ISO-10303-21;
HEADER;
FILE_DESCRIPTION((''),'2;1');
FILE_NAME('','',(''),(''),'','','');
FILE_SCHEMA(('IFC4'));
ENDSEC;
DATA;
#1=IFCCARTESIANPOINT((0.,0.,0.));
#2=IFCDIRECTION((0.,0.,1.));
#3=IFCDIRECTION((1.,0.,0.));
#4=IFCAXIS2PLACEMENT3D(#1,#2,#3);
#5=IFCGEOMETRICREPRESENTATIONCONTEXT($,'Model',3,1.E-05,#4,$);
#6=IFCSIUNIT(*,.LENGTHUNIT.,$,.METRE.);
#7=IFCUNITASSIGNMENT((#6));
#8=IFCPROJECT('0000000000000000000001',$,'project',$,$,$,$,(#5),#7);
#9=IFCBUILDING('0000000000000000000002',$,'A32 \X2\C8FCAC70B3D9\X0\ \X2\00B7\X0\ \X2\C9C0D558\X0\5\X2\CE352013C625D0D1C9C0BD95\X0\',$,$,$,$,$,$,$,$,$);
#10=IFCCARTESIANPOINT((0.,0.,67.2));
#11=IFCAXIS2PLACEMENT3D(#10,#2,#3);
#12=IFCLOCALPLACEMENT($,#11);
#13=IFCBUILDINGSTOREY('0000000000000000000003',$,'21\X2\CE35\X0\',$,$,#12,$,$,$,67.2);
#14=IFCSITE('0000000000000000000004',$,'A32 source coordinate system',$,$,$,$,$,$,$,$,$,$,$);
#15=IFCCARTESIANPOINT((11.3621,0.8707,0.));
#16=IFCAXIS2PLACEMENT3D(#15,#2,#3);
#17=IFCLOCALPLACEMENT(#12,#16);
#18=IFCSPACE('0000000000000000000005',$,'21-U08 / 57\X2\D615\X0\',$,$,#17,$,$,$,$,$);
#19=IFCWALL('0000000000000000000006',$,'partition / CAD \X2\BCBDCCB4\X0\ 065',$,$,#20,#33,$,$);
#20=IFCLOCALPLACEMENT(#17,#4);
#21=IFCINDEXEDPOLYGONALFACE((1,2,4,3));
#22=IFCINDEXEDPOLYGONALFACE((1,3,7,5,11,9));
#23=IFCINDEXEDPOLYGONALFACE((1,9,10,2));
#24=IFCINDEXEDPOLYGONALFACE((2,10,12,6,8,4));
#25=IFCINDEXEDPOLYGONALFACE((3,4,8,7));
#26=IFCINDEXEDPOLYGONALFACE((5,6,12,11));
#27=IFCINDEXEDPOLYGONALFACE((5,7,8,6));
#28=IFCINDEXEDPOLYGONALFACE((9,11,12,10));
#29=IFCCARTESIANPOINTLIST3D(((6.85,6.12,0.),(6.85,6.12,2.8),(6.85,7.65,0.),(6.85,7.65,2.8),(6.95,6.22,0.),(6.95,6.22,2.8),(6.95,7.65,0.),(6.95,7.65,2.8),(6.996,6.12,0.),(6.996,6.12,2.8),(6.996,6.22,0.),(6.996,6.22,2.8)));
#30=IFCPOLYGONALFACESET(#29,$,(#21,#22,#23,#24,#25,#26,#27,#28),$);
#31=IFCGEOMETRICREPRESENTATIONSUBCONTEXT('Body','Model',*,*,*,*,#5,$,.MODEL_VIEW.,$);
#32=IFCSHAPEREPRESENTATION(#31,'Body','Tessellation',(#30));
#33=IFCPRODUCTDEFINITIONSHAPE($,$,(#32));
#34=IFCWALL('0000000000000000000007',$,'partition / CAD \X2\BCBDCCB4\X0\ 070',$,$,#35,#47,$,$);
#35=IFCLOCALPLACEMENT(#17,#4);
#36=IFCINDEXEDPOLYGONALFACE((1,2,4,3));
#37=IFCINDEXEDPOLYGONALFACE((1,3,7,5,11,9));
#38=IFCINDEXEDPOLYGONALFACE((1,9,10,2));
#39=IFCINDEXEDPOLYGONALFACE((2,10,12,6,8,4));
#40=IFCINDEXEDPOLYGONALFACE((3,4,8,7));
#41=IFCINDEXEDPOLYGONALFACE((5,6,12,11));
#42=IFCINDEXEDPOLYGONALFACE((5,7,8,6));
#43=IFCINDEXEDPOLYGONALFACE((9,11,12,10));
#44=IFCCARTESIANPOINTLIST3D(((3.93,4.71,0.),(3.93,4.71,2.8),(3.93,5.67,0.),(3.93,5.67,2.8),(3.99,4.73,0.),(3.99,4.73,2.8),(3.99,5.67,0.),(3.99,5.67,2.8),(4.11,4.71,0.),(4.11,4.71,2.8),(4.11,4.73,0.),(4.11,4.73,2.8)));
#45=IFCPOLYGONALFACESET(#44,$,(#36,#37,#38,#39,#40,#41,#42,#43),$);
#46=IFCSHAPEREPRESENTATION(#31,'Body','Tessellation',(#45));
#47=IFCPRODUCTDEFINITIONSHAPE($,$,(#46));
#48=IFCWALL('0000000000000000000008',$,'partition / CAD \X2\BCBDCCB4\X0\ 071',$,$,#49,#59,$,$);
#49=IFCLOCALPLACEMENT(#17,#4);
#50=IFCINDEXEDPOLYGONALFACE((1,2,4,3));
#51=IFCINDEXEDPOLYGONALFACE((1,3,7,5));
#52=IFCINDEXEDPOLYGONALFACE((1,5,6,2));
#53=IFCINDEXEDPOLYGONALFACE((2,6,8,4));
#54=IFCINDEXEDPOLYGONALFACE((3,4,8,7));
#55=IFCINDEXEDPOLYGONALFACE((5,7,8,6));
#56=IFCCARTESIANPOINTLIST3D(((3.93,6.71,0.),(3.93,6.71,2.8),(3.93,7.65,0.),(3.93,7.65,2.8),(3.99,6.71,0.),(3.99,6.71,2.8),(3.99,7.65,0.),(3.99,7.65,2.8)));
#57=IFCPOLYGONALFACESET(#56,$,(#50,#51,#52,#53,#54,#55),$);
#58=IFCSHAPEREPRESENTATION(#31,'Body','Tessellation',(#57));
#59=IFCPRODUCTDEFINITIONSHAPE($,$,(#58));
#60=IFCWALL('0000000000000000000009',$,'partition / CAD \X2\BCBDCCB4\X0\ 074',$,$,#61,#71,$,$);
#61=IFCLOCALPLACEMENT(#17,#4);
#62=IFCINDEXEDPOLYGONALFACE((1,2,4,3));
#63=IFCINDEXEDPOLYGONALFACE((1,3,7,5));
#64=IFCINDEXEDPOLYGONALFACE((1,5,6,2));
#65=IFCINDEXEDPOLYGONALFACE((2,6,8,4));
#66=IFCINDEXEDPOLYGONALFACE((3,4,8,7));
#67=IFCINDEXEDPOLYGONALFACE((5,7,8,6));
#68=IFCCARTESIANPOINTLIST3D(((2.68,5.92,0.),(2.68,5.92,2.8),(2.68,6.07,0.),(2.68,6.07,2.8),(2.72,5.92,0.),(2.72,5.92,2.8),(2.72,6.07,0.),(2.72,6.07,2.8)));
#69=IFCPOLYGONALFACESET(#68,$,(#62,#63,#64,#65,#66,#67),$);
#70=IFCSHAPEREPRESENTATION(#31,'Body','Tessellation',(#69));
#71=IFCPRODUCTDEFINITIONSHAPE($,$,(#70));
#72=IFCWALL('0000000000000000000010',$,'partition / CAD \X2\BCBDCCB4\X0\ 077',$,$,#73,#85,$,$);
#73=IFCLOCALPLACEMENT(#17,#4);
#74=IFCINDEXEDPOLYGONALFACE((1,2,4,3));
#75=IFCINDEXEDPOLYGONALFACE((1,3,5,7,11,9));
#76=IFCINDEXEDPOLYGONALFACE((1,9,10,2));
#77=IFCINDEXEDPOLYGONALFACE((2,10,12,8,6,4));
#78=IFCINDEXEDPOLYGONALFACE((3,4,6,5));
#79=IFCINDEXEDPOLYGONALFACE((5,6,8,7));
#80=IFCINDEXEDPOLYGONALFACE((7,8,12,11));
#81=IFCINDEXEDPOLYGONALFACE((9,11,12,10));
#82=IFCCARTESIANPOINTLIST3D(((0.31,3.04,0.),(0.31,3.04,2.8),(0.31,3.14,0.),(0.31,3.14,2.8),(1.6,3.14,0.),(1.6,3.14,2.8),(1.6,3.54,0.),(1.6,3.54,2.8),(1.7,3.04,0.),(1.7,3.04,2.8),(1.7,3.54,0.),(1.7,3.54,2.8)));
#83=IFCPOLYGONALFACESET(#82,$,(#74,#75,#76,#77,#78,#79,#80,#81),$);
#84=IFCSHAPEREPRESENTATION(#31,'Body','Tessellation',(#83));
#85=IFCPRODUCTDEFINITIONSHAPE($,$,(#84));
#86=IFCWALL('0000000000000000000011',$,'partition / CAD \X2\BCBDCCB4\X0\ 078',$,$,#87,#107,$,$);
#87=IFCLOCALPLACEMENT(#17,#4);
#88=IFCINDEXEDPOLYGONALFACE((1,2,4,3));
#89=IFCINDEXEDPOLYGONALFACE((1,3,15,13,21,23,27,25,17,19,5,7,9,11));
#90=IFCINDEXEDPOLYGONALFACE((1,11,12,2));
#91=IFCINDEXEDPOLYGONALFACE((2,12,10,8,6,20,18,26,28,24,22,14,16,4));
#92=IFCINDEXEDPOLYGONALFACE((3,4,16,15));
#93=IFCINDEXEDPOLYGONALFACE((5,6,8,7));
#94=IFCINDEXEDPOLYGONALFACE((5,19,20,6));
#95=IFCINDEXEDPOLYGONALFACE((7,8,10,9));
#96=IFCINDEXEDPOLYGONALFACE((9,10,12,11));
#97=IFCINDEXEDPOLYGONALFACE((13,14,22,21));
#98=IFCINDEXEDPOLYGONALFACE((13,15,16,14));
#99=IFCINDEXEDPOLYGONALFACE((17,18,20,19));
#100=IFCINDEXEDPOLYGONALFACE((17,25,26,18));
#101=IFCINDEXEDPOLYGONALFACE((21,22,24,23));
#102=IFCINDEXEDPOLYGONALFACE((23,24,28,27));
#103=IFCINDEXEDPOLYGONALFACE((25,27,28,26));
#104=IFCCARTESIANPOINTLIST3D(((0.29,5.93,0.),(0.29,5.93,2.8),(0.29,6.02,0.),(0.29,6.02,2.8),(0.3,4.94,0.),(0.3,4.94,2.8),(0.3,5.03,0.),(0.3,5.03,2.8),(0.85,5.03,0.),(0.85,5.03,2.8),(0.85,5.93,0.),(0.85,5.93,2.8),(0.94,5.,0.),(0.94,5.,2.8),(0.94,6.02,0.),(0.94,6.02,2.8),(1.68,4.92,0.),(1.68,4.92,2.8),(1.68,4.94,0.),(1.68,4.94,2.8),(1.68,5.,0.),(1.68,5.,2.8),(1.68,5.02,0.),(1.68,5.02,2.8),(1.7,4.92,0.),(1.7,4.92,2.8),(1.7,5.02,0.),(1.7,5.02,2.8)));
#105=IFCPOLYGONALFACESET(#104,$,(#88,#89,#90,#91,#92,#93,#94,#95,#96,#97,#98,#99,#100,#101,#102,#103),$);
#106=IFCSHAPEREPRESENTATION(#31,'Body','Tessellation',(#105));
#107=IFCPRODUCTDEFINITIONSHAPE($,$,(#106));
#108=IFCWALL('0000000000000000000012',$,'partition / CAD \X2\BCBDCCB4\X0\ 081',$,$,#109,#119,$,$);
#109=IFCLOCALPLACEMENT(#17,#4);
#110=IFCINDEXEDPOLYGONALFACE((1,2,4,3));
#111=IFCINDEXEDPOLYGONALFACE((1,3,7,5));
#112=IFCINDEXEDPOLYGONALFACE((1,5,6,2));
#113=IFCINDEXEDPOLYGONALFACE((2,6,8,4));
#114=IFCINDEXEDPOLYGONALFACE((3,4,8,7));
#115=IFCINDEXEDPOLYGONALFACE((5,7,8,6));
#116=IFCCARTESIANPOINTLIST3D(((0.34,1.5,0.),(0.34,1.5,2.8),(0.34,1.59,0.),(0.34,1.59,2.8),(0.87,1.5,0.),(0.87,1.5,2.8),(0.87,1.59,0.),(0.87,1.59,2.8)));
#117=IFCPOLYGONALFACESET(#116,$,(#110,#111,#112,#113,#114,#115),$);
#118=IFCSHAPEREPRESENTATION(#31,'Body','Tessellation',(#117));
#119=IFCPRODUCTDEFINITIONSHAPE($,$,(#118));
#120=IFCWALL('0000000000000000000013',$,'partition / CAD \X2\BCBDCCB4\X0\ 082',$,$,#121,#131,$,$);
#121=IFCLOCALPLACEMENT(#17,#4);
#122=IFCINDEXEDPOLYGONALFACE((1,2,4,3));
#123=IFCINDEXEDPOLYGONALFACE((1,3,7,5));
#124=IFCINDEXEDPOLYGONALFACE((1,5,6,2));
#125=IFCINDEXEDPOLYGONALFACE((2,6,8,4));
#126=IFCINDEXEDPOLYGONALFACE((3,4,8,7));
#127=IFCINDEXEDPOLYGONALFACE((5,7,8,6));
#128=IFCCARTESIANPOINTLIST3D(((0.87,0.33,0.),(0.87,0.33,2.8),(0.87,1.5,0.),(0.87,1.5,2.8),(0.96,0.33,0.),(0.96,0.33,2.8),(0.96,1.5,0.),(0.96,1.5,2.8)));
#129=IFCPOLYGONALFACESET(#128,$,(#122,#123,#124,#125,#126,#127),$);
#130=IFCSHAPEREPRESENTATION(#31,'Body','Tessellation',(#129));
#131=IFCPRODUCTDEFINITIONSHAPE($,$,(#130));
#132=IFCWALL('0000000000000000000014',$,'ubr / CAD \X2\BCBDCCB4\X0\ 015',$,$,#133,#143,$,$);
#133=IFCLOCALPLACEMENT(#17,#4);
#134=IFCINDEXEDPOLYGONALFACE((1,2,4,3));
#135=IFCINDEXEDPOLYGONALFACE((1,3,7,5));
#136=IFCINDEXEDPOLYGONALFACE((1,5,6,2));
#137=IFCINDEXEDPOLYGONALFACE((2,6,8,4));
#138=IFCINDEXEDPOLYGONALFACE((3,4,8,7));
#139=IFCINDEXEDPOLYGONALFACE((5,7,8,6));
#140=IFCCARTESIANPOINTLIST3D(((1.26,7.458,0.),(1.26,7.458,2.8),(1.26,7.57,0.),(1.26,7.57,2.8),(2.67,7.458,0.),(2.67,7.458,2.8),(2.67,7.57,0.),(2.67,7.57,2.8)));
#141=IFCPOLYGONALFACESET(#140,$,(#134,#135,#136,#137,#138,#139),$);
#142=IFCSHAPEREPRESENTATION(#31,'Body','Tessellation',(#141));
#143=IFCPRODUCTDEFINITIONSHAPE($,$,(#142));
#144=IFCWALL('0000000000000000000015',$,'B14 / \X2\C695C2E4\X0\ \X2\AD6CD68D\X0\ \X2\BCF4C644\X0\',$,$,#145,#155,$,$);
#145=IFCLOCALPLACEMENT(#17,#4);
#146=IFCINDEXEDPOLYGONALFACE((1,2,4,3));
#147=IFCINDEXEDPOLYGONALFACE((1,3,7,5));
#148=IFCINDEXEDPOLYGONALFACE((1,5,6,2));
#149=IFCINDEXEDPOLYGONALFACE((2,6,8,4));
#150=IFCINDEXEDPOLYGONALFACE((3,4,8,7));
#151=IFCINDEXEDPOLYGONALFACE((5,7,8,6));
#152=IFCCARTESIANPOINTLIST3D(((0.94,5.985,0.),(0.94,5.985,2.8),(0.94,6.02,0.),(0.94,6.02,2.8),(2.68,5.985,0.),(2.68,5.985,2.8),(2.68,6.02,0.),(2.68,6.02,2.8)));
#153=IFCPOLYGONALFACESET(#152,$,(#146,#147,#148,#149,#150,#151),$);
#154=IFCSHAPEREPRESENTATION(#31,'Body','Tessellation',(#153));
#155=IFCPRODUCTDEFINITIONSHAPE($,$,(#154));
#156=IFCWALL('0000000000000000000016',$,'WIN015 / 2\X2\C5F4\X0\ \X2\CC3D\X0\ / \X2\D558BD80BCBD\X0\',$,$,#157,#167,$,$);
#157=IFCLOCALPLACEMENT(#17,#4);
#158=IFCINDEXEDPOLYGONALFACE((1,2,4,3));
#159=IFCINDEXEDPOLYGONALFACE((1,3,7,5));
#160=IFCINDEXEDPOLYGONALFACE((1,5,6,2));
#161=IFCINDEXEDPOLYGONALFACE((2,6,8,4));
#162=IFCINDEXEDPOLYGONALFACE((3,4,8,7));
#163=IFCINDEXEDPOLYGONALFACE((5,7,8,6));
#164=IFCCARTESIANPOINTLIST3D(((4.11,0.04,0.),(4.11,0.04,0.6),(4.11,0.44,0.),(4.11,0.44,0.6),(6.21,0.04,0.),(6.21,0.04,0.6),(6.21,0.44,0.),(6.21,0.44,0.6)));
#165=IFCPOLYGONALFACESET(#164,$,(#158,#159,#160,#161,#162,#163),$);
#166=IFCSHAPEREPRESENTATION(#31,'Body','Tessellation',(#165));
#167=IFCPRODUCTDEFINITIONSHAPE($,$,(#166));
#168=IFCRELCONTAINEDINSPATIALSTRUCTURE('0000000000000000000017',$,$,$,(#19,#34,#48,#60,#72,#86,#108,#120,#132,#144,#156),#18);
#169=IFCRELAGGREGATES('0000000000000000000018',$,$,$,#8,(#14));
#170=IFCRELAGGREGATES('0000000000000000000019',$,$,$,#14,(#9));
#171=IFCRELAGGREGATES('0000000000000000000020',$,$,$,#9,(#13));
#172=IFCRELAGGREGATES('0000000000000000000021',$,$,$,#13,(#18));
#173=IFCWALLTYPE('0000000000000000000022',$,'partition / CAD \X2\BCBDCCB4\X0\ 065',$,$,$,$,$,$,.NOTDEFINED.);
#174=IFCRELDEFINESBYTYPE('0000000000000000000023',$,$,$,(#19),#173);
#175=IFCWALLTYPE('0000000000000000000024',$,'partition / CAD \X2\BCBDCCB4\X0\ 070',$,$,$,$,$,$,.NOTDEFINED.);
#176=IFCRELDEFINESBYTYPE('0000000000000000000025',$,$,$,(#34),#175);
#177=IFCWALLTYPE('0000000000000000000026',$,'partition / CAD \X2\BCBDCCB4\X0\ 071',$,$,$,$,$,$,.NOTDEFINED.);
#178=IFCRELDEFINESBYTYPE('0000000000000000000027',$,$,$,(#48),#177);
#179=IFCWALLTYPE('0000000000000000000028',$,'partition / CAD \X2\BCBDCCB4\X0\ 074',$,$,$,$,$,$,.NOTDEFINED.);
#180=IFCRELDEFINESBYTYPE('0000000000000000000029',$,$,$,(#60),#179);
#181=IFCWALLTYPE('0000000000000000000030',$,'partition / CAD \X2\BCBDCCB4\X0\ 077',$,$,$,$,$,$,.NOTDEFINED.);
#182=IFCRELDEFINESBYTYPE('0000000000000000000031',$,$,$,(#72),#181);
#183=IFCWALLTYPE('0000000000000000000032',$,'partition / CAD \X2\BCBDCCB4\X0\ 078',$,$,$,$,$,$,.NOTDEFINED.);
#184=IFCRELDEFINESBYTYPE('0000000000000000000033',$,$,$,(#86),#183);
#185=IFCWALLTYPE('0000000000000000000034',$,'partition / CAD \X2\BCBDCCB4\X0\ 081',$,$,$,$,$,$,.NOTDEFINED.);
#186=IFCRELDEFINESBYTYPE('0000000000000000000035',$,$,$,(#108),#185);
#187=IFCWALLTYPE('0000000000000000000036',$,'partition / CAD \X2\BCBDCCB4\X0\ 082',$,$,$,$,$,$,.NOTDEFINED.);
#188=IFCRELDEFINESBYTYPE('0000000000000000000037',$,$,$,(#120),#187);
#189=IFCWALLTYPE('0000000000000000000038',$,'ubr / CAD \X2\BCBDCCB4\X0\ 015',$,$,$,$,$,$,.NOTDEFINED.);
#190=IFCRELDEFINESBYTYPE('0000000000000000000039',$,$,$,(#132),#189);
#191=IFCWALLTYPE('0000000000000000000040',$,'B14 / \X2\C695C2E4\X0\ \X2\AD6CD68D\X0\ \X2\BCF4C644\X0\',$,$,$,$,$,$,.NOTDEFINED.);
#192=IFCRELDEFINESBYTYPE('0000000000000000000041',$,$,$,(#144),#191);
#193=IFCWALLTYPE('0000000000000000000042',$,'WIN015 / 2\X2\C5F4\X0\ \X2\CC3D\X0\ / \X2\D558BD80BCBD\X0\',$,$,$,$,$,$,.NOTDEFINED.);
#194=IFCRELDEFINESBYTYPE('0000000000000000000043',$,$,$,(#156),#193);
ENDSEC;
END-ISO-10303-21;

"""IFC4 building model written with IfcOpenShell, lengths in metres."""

from ifc_helpers import new_model, si_unit, frame, origin, origin_with_axes, place, context, subcontext, project, spatial, polyline, outline, extrude, source, transform, mapped, type_object, type_shapes, element, save


model = new_model("IFC4")

# Units and contexts
model_context = context("Model", 3, precision=1e-05, world=origin_with_axes())
body_context = subcontext(model_context, "Body", "Model", "MODEL_VIEW")
ifc_project = project(units=[si_unit("LENGTHUNIT", "METRE")], contexts=[model_context])

# Site, building, storey, space
storey_placement = place(None, frame((0.0, 0.0, 67.2), z_axis=(0.0, 0.0, 1.0), x_axis=(1.0, 0.0, 0.0)))
space_placement = place(storey_placement, frame((11.3621, 0.8707, 0.0), z_axis=(0.0, 0.0, 1.0), x_axis=(1.0, 0.0, 0.0)))
site = spatial("IfcSite", under=ifc_project, Name="A32 source coordinate system")
building = spatial("IfcBuilding", under=site, Name="A32 주거동 · 지하5층–옥탑지붕")
storey = spatial("IfcBuildingStorey", under=building, at=storey_placement, Name="21층", Elevation=67.2)
space = spatial("IfcSpace", under=storey, at=space_placement, Name="21-U08 / 57형")

# Walls
wall_type_1 = type_object("IfcWallType", Name="partition / CAD 벽체 065", PredefinedType="NOTDEFINED")
shared_shape_1 = source(origin(), body_context, "Body", "SweptSolid", [
    extrude(outline(polyline([(6.95, 7.65), (6.95, 6.22), (6.996, 6.22), (6.996, 6.12), (6.85, 6.12), (6.85, 7.65), (6.95, 7.65)])), origin(), (0.0, 0.0, 1.0), 2.8),
])
type_shapes(wall_type_1, [shared_shape_1])
wall_1_placement = place(space_placement, origin_with_axes())
element("IfcWall", 1, at=wall_1_placement, inside=space, type_object=wall_type_1, Name="partition / CAD 벽체 065", context=body_context, shape_type="MappedRepresentation", body=[
    mapped(shared_shape_1, transform((0.0, 0.0, 0.0), scale=1.0)),
])
wall_type_2 = type_object("IfcWallType", Name="partition / CAD 벽체 070", PredefinedType="NOTDEFINED")
shared_shape_2 = source(origin(), body_context, "Body", "SweptSolid", [
    extrude(outline(polyline([(4.11, 4.73), (4.11, 4.71), (3.93, 4.71), (3.93, 5.67), (3.99, 5.67), (3.99, 4.73), (4.11, 4.73)])), origin(), (0.0, 0.0, 1.0), 2.8),
])
type_shapes(wall_type_2, [shared_shape_2])
wall_2_placement = place(space_placement, origin_with_axes())
element("IfcWall", 2, at=wall_2_placement, inside=space, type_object=wall_type_2, Name="partition / CAD 벽체 070", context=body_context, shape_type="MappedRepresentation", body=[
    mapped(shared_shape_2, transform((0.0, 0.0, 0.0), scale=1.0)),
])
wall_type_3 = type_object("IfcWallType", Name="partition / CAD 벽체 071", PredefinedType="NOTDEFINED")
shared_shape_3 = source(origin(), body_context, "Body", "SweptSolid", [
    extrude(outline(polyline([(3.93, 6.71), (3.93, 7.65), (3.99, 7.65), (3.99, 6.71), (3.93, 6.71)])), origin(), (0.0, 0.0, 1.0), 2.8),
])
type_shapes(wall_type_3, [shared_shape_3])
wall_3_placement = place(space_placement, origin_with_axes())
element("IfcWall", 3, at=wall_3_placement, inside=space, type_object=wall_type_3, Name="partition / CAD 벽체 071", context=body_context, shape_type="MappedRepresentation", body=[
    mapped(shared_shape_3, transform((0.0, 0.0, 0.0), scale=1.0)),
])
wall_type_4 = type_object("IfcWallType", Name="partition / CAD 벽체 074", PredefinedType="NOTDEFINED")
shared_shape_4 = source(origin(), body_context, "Body", "SweptSolid", [
    extrude(outline(polyline([(2.72, 6.07), (2.72, 5.92), (2.68, 5.92), (2.68, 6.07), (2.72, 6.07)])), origin(), (0.0, 0.0, 1.0), 2.8),
])
type_shapes(wall_type_4, [shared_shape_4])
wall_4_placement = place(space_placement, origin_with_axes())
element("IfcWall", 4, at=wall_4_placement, inside=space, type_object=wall_type_4, Name="partition / CAD 벽체 074", context=body_context, shape_type="MappedRepresentation", body=[
    mapped(shared_shape_4, transform((0.0, 0.0, 0.0), scale=1.0)),
])
wall_type_5 = type_object("IfcWallType", Name="partition / CAD 벽체 077", PredefinedType="NOTDEFINED")
shared_shape_5 = source(origin(), body_context, "Body", "SweptSolid", [
    extrude(outline(polyline([(1.7, 3.54), (1.7, 3.04), (0.31, 3.04), (0.31, 3.14), (1.6, 3.14), (1.6, 3.54), (1.7, 3.54)])), origin(), (0.0, 0.0, 1.0), 2.8),
])
type_shapes(wall_type_5, [shared_shape_5])
wall_5_placement = place(space_placement, origin_with_axes())
element("IfcWall", 5, at=wall_5_placement, inside=space, type_object=wall_type_5, Name="partition / CAD 벽체 077", context=body_context, shape_type="MappedRepresentation", body=[
    mapped(shared_shape_5, transform((0.0, 0.0, 0.0), scale=1.0)),
])
wall_type_6 = type_object("IfcWallType", Name="partition / CAD 벽체 078", PredefinedType="NOTDEFINED")
shared_shape_6 = source(origin(), body_context, "Body", "SweptSolid", [
    extrude(outline(polyline([(1.7, 4.92), (1.68, 4.92), (1.68, 4.94), (0.3, 4.94), (0.3, 5.03), (0.85, 5.03), (0.85, 5.93), (0.29, 5.93), (0.29, 6.02), (0.94, 6.02), (0.94, 5.0), (1.68, 5.0), (1.68, 5.02), (1.7, 5.02), (1.7, 4.92)])), origin(), (0.0, 0.0, 1.0), 2.8),
])
type_shapes(wall_type_6, [shared_shape_6])
wall_6_placement = place(space_placement, origin_with_axes())
element("IfcWall", 6, at=wall_6_placement, inside=space, type_object=wall_type_6, Name="partition / CAD 벽체 078", context=body_context, shape_type="MappedRepresentation", body=[
    mapped(shared_shape_6, transform((0.0, 0.0, 0.0), scale=1.0)),
])
wall_type_7 = type_object("IfcWallType", Name="partition / CAD 벽체 081", PredefinedType="NOTDEFINED")
shared_shape_7 = source(origin(), body_context, "Body", "SweptSolid", [
    extrude(outline(polyline([(0.34, 1.59), (0.87, 1.59), (0.87, 1.5), (0.34, 1.5), (0.34, 1.59)])), origin(), (0.0, 0.0, 1.0), 2.8),
])
type_shapes(wall_type_7, [shared_shape_7])
wall_7_placement = place(space_placement, origin_with_axes())
element("IfcWall", 7, at=wall_7_placement, inside=space, type_object=wall_type_7, Name="partition / CAD 벽체 081", context=body_context, shape_type="MappedRepresentation", body=[
    mapped(shared_shape_7, transform((0.0, 0.0, 0.0), scale=1.0)),
])
wall_type_8 = type_object("IfcWallType", Name="partition / CAD 벽체 082", PredefinedType="NOTDEFINED")
shared_shape_8 = source(origin(), body_context, "Body", "SweptSolid", [
    extrude(outline(polyline([(0.96, 0.33), (0.87, 0.33), (0.87, 1.5), (0.96, 1.5), (0.96, 0.33)])), origin(), (0.0, 0.0, 1.0), 2.8),
])
type_shapes(wall_type_8, [shared_shape_8])
wall_8_placement = place(space_placement, origin_with_axes())
element("IfcWall", 8, at=wall_8_placement, inside=space, type_object=wall_type_8, Name="partition / CAD 벽체 082", context=body_context, shape_type="MappedRepresentation", body=[
    mapped(shared_shape_8, transform((0.0, 0.0, 0.0), scale=1.0)),
])
wall_type_9 = type_object("IfcWallType", Name="ubr / CAD 벽체 015", PredefinedType="NOTDEFINED")
shared_shape_9 = source(origin(), body_context, "Body", "SweptSolid", [
    extrude(outline(polyline([(2.67, 7.57), (2.67, 7.458), (1.26, 7.458), (1.26, 7.57), (2.67, 7.57)])), origin(), (0.0, 0.0, 1.0), 2.8),
])
type_shapes(wall_type_9, [shared_shape_9])
wall_9_placement = place(space_placement, origin_with_axes())
element("IfcWall", 9, at=wall_9_placement, inside=space, type_object=wall_type_9, Name="ubr / CAD 벽체 015", context=body_context, shape_type="MappedRepresentation", body=[
    mapped(shared_shape_9, transform((0.0, 0.0, 0.0), scale=1.0)),
])
wall_type_10 = type_object("IfcWallType", Name="B14 / 욕실 구획 보완", PredefinedType="NOTDEFINED")
shared_shape_10 = source(origin(), body_context, "Body", "SweptSolid", [
    extrude(outline(polyline([(2.68, 5.985), (0.94, 5.985), (0.94, 6.02), (2.68, 6.02), (2.68, 5.985)])), origin(), (0.0, 0.0, 1.0), 2.8),
])
type_shapes(wall_type_10, [shared_shape_10])
wall_10_placement = place(space_placement, origin_with_axes())
element("IfcWall", 10, at=wall_10_placement, inside=space, type_object=wall_type_10, Name="B14 / 욕실 구획 보완", context=body_context, shape_type="MappedRepresentation", body=[
    mapped(shared_shape_10, transform((0.0, 0.0, 0.0), scale=1.0)),
])
wall_type_11 = type_object("IfcWallType", Name="WIN015 / 2열 창 / 하부벽", PredefinedType="NOTDEFINED")
shared_shape_11 = source(origin(), body_context, "Body", "SweptSolid", [
    extrude(outline(polyline([(4.11, 0.04), (4.11, 0.44), (6.21, 0.44), (6.21, 0.04), (4.11, 0.04)])), origin(), (0.0, 0.0, 1.0), 0.6),
])
type_shapes(wall_type_11, [shared_shape_11])
wall_11_placement = place(space_placement, origin_with_axes())
element("IfcWall", 11, at=wall_11_placement, inside=space, type_object=wall_type_11, Name="WIN015 / 2열 창 / 하부벽", context=body_context, shape_type="MappedRepresentation", body=[
    mapped(shared_shape_11, transform((0.0, 0.0, 0.0), scale=1.0)),
])

save(model, "model.ifc")
